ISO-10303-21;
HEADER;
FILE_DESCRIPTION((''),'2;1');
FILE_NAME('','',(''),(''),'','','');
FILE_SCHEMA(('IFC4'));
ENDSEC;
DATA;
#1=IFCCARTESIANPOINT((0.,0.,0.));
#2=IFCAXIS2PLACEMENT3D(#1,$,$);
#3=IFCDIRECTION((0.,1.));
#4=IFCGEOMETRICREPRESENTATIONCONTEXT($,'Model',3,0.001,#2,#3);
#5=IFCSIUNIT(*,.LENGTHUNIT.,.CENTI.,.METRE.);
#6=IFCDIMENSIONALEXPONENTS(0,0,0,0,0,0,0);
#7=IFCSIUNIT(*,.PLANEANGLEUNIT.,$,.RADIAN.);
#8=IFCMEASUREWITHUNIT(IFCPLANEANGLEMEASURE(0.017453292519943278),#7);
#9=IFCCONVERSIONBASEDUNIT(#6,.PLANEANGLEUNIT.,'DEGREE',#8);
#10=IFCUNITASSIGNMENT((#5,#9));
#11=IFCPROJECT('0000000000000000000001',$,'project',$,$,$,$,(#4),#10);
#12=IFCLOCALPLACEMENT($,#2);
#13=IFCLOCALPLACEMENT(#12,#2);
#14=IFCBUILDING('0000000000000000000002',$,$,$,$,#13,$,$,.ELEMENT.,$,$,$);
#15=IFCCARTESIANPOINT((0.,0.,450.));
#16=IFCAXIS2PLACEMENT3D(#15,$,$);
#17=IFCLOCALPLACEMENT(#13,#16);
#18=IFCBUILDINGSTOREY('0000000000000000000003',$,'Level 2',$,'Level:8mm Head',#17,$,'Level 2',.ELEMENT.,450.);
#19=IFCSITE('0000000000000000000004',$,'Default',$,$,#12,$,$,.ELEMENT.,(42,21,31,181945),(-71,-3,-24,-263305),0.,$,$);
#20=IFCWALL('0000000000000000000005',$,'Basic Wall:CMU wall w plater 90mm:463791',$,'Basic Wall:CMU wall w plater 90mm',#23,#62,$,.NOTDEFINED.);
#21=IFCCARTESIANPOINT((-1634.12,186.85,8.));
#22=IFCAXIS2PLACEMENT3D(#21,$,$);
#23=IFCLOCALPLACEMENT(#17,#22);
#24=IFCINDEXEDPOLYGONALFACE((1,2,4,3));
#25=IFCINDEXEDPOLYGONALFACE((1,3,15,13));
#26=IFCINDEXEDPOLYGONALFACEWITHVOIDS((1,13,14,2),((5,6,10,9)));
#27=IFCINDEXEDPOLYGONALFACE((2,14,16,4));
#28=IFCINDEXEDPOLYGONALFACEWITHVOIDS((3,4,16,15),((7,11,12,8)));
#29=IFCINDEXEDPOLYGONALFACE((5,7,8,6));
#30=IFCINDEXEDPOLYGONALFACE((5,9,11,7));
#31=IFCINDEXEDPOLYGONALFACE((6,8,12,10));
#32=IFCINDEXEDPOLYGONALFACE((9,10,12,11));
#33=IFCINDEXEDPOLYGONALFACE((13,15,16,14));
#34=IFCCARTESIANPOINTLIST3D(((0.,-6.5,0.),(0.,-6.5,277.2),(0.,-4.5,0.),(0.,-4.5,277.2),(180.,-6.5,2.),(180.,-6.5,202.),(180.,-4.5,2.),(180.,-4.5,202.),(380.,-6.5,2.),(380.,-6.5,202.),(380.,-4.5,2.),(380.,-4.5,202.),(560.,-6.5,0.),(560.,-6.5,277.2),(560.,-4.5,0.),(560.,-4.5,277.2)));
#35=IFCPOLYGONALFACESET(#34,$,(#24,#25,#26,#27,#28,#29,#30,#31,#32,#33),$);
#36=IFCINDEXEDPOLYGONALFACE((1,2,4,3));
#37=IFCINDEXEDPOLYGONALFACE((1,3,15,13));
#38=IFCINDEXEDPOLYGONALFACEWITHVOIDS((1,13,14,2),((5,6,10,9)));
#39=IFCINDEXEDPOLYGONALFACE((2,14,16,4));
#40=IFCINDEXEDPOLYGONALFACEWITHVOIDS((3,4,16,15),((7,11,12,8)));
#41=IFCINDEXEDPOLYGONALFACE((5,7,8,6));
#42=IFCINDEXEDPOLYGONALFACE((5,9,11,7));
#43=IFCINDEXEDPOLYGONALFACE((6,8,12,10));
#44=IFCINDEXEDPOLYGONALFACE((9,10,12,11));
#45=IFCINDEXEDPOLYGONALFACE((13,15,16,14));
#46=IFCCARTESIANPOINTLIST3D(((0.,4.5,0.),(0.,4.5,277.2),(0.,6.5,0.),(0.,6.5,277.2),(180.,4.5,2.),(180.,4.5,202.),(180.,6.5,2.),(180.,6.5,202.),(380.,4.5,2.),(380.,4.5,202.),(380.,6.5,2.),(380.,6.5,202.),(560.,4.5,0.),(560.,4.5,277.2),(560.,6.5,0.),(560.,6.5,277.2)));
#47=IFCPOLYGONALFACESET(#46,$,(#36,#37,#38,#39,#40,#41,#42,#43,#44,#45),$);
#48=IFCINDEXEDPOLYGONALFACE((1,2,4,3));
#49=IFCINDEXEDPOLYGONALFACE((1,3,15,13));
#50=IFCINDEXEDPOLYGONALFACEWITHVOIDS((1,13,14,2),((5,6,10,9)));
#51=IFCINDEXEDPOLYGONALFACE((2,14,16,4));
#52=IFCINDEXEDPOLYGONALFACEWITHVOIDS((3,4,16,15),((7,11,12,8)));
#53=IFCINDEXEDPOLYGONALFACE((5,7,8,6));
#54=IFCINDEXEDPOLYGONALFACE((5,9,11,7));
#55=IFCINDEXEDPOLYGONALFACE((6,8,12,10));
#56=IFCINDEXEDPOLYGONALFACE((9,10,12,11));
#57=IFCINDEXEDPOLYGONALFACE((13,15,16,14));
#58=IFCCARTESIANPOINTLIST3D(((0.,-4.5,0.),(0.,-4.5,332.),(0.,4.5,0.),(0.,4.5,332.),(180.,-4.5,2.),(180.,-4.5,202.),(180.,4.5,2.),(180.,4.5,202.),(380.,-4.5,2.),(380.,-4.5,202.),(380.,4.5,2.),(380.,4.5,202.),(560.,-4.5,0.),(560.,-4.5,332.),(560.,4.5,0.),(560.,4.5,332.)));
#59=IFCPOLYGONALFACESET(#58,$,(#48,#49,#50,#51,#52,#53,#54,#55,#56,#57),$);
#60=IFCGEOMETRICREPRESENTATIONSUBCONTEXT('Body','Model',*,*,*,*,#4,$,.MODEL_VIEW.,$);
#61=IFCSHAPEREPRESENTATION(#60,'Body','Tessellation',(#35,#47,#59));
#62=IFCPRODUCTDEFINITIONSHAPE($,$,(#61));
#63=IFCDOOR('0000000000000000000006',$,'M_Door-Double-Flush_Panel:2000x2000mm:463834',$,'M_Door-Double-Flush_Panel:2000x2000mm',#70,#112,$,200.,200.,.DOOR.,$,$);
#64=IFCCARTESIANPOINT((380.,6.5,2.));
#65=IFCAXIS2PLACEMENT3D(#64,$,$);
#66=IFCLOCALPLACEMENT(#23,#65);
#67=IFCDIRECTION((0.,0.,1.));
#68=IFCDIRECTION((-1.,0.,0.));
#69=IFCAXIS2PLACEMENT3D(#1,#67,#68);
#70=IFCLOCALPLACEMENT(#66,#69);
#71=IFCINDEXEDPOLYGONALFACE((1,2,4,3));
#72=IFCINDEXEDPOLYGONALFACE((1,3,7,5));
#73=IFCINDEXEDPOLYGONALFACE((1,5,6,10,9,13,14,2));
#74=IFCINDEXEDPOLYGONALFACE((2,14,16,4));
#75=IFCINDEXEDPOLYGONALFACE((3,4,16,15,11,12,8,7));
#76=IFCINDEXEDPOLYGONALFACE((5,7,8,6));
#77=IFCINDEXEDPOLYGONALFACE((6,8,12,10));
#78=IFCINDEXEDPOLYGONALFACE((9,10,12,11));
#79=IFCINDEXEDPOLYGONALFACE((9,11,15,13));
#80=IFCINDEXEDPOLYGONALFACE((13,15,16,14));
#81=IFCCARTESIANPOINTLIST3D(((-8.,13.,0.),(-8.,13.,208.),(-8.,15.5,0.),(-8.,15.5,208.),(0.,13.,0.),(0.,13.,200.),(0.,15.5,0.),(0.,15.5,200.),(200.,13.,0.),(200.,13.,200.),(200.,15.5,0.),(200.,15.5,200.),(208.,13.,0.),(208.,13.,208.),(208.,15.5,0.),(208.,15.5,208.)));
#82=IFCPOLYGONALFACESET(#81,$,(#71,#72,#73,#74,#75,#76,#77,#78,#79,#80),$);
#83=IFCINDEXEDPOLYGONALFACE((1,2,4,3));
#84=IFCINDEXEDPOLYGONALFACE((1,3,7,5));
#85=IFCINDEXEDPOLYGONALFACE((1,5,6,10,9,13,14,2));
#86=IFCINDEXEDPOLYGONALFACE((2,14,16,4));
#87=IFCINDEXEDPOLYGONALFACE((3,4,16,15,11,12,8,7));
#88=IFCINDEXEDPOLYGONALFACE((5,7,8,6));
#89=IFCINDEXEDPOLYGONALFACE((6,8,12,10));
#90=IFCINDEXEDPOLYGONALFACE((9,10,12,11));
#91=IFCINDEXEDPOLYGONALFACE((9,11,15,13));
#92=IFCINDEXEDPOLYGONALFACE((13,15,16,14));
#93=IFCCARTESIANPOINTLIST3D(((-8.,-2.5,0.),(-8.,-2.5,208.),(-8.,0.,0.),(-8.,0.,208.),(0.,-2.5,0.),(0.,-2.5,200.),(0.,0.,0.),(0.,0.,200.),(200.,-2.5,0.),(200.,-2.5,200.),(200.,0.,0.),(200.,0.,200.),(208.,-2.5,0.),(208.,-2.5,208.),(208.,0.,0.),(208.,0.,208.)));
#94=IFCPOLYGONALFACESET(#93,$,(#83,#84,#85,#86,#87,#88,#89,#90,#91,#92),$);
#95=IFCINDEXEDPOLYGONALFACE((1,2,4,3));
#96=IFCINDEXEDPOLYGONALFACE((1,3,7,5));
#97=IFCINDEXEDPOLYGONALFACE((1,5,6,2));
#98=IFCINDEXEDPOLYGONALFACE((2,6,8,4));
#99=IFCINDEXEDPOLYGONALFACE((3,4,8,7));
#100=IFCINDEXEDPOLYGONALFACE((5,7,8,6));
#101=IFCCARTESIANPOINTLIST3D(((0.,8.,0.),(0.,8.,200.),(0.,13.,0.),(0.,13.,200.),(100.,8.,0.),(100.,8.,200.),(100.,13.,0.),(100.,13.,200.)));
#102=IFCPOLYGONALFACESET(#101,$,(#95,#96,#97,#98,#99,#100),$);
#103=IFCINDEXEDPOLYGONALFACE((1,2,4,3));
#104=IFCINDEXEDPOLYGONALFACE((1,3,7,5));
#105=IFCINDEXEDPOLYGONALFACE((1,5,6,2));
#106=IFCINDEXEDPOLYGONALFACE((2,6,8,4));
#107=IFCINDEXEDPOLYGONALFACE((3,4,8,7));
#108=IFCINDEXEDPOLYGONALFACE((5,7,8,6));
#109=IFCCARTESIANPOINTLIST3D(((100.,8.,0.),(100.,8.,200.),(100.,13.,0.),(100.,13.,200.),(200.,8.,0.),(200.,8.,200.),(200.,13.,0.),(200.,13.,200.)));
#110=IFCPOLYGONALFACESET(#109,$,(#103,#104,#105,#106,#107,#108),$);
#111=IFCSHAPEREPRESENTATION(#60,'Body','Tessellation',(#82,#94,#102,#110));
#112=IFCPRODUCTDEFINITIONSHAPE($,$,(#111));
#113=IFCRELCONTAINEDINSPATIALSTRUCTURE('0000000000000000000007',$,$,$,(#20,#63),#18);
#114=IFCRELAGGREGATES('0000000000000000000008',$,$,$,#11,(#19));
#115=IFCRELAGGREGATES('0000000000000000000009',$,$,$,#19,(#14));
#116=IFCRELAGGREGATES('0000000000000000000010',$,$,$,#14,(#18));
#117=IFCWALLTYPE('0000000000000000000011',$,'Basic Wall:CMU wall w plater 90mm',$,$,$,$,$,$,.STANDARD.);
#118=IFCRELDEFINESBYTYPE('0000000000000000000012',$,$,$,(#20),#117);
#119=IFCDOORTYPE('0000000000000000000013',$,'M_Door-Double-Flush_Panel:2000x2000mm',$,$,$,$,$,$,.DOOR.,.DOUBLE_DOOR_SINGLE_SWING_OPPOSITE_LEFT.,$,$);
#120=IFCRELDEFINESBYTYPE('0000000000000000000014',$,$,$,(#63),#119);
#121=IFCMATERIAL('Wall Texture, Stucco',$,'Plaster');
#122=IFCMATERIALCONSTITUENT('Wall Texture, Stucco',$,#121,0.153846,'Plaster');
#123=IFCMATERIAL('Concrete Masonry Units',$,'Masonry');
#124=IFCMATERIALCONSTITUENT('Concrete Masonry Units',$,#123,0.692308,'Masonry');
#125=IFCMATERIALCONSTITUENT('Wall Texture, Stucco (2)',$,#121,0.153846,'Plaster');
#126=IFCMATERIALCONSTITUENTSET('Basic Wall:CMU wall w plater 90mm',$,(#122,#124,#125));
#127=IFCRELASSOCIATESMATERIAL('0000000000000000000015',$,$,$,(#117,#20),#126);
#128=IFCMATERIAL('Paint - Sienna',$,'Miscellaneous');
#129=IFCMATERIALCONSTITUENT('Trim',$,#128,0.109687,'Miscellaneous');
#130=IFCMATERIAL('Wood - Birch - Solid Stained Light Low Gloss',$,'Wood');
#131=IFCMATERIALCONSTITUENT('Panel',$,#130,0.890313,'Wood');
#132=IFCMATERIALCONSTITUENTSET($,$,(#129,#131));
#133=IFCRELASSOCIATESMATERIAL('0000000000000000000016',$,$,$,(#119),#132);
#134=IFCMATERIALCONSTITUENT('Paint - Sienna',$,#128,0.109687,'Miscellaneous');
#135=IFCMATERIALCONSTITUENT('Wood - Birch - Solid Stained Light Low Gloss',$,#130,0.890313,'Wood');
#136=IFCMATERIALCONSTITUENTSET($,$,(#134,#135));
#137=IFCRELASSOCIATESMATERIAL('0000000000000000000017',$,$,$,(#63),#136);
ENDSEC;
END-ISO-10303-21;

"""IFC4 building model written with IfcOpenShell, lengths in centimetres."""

from ifc_helpers import new_model, entity, si_unit, converted_unit, direction, frame, origin, place, context, subcontext, project, spatial, indexed_curve, outline, extrude, source, transform, mapped, material, constituent, constituent_set, type_object, type_shapes, element, fill, save


model = new_model("IFC4")

# Units and contexts
model_context = context("Model", 3, precision=0.001, world=origin(), true_north=direction((0.0, 1.0)))
body_context = subcontext(model_context, "Body", "Model", "MODEL_VIEW")
ifc_project = project(units=[si_unit("LENGTHUNIT", "METRE", prefix="CENTI"), converted_unit("PLANEANGLEUNIT", "DEGREE", entity("IfcPlaneAngleMeasure", 0.017453292519943278), si_unit("PLANEANGLEUNIT", "RADIAN"), dimensions=[0, 0, 0, 0, 0, 0, 0])], contexts=[model_context])

# Site, building, storey
site_placement = place(None, origin())
site = spatial("IfcSite", under=ifc_project, at=site_placement, Name="Default", CompositionType="ELEMENT", RefLatitude=(42, 21, 31, 181945), RefLongitude=(-71, -3, -24, -263305), RefElevation=0.0)
building_placement = place(site_placement, origin())
building = spatial("IfcBuilding", under=site, at=building_placement, CompositionType="ELEMENT")
storey_placement = place(building_placement, frame((0.0, 0.0, 450.0)))
storey = spatial("IfcBuildingStorey", under=building, at=storey_placement, Name="Level 2", ObjectType="Level:8mm Head", LongName="Level 2", CompositionType="ELEMENT", Elevation=450.0)

# Shared definitions
ifc_material_1 = material(Name="Concrete Masonry Units", Category="Masonry")

# Shared definitions
ifc_material_2 = material(Name="Wall Texture, Stucco", Category="Plaster")
ifc_constituent_1 = constituent(ifc_material_2, Name="Wall Texture, Stucco", Category="Plaster", fraction=0.153846)
ifc_constituent_2 = constituent(ifc_material_1, Name="Concrete Masonry Units", Category="Masonry", fraction=0.692308)
ifc_constituent_3 = constituent(ifc_material_2, Name="Wall Texture, Stucco (2)", Category="Plaster", fraction=0.153846)
ifc_constituent_set_1 = constituent_set(constituents=[ifc_constituent_1, ifc_constituent_2, ifc_constituent_3], Name="Basic Wall:CMU wall w plater 90mm")
wall_type_1 = type_object("IfcWallType", Name="Basic Wall:CMU wall w plater 90mm", PredefinedType="STANDARD", material=ifc_constituent_set_1)

# Wall, opening, door
wall_1_placement = place(storey_placement, frame((-1634.12, 186.85, 8.0)))
wall_1 = element("IfcWall", 1, at=wall_1_placement, inside=storey, type_object=wall_type_1, material=ifc_constituent_set_1, Name="Basic Wall:CMU wall w plater 90mm:463791", ObjectType="Basic Wall:CMU wall w plater 90mm", PredefinedType="NOTDEFINED", context=body_context, shape_type="SweptSolid", body=[
    extrude(outline(indexed_curve([(-138.6, -280.0), (138.6, -280.0), (138.6, -278.0), (138.6, 278.0), (138.6, 280.0), (-138.6, 280.0), (-138.6, 278.0), (-138.6, -278.0), (-138.6, -280.0)], self_intersect=False), holes=[indexed_curve([(-136.6, -100.0), (-136.6, 100.0), (63.4, 100.0), (63.4, -100.0), (-136.6, -100.0)], self_intersect=False)]), frame((280.0, -6.5, 138.6), z_axis=(0.0, 1.0, 0.0), x_axis=(0.0, 0.0, 1.0)), (0.0, 0.0, 1.0), 2.0),
    extrude(outline(indexed_curve([(-138.6, -280.0), (138.6, -280.0), (138.6, 280.0), (-138.6, 280.0), (-138.6, -280.0)], self_intersect=False), holes=[indexed_curve([(-136.6, -100.0), (-136.6, 100.0), (63.4, 100.0), (63.4, -100.0), (-136.6, -100.0)], self_intersect=False)]), frame((280.0, 4.5, 138.6), z_axis=(0.0, 1.0, 0.0), x_axis=(0.0, 0.0, 1.0)), (0.0, 0.0, 1.0), 2.0),
    extrude(outline(indexed_curve([(-203.07, -280.0), (74.13, -280.0), (128.93, -280.0), (128.93, 280.0), (74.13, 280.0), (-203.07, 280.0), (-203.07, -280.0)], self_intersect=False), holes=[indexed_curve([(-201.07, -100.0), (-201.07, 100.0), (-1.07, 100.0), (-1.07, -100.0), (-201.07, -100.0)], self_intersect=False)]), frame((280.0, -4.5, 203.07), z_axis=(0.0, 1.0, 0.0), x_axis=(0.0, 0.0, 1.0)), (0.0, 0.0, 1.0), 9.0),
])
opening_1_placement = place(wall_1_placement, frame((380.0, 6.5, 2.0)))
opening_1 = element("IfcOpeningElement", 2, at=opening_1_placement, cuts=wall_1, PredefinedType="OPENING", context=body_context, shape_type="SweptSolid", body=[
    extrude(outline(indexed_curve([(0.0, 200.0), (0.0, 0.0), (200.0, 0.0), (200.0, 200.0), (0.0, 200.0)], self_intersect=False)), frame((0.0, 0.0, 0.0), z_axis=(0.0, -1.0, 0.0), x_axis=(0.0, 0.0, 1.0)), (0.0, 0.0, 1.0), 13.0),
])
ifc_material_3 = material(Name="Paint - Sienna", Category="Miscellaneous")
ifc_constituent_4 = constituent(ifc_material_3, Name="Paint - Sienna", Category="Miscellaneous", fraction=0.109687)
ifc_material_4 = material(Name="Wood - Birch - Solid Stained Light Low Gloss", Category="Wood")
ifc_constituent_5 = constituent(ifc_material_4, Name="Wood - Birch - Solid Stained Light Low Gloss", Category="Wood", fraction=0.890313)
ifc_constituent_set_2 = constituent_set(constituents=[ifc_constituent_4, ifc_constituent_5])
ifc_constituent_6 = constituent(ifc_material_3, Name="Trim", Category="Miscellaneous", fraction=0.109687)
ifc_constituent_7 = constituent(ifc_material_4, Name="Panel", Category="Wood", fraction=0.890313)
ifc_constituent_set_3 = constituent_set(constituents=[ifc_constituent_6, ifc_constituent_7])
door_type = type_object("IfcDoorType", Name="M_Door-Double-Flush_Panel:2000x2000mm", OperationType="DOUBLE_DOOR_SINGLE_SWING_OPPOSITE_LEFT", PredefinedType="DOOR", material=ifc_constituent_set_3)
shared_shape_1 = source(origin(), body_context, "Body", "SweptSolid", [
    extrude(outline(indexed_curve([(-98.0, 100.0), (102.0, 100.0), (102.0, 108.0), (-106.0, 108.0), (-106.0, -108.0), (102.0, -108.0), (102.0, -100.0), (-98.0, -100.0), (-98.0, 100.0)], self_intersect=False)), frame((100.0, 13.0, 102.0), z_axis=(0.0, 1.0, 0.0), x_axis=(0.0, 0.0, -1.0)), (0.0, 0.0, 1.0), 2.5),
    extrude(outline(indexed_curve([(-98.0, 100.0), (102.0, 100.0), (102.0, 108.0), (-106.0, 108.0), (-106.0, -108.0), (102.0, -108.0), (102.0, -100.0), (-98.0, -100.0), (-98.0, 100.0)], self_intersect=False)), frame((100.0, -2.5, 102.0), z_axis=(0.0, 1.0, 0.0), x_axis=(0.0, 0.0, -1.0)), (0.0, 0.0, 1.0), 2.5),
    extrude(outline(indexed_curve([(-2.5, -50.0), (2.5, -50.0), (2.5, 50.0), (-2.5, 50.0), (-2.5, -50.0)], self_intersect=False)), frame((50.0, 10.5, 0.0), z_axis=(0.0, 0.0, 1.0), x_axis=(0.0, -1.0, 0.0)), (0.0, 0.0, 1.0), 200.0),
    extrude(outline(indexed_curve([(-2.5, -50.0), (2.5, -50.0), (2.5, 50.0), (-2.5, 50.0), (-2.5, -50.0)], self_intersect=False)), frame((150.0, 10.5, 0.0), z_axis=(0.0, 0.0, 1.0), x_axis=(0.0, -1.0, 0.0)), (0.0, 0.0, 1.0), 200.0),
])
type_shapes(door_type, [shared_shape_1])
door_placement = place(opening_1_placement, frame((0.0, 0.0, 0.0), z_axis=(0.0, 0.0, 1.0), x_axis=(-1.0, 0.0, 0.0)))
door = element("IfcDoor", 3, at=door_placement, inside=storey, type_object=door_type, material=ifc_constituent_set_2, Name="M_Door-Double-Flush_Panel:2000x2000mm:463834", ObjectType="M_Door-Double-Flush_Panel:2000x2000mm", OverallHeight=200.0, OverallWidth=200.0, PredefinedType="DOOR", context=body_context, shape_type="MappedRepresentation", body=[
    mapped(shared_shape_1, transform((0.0, 0.0, 0.0), scale=1.0)),
])
fill(opening_1, door)

save(model, "model.ifc")
